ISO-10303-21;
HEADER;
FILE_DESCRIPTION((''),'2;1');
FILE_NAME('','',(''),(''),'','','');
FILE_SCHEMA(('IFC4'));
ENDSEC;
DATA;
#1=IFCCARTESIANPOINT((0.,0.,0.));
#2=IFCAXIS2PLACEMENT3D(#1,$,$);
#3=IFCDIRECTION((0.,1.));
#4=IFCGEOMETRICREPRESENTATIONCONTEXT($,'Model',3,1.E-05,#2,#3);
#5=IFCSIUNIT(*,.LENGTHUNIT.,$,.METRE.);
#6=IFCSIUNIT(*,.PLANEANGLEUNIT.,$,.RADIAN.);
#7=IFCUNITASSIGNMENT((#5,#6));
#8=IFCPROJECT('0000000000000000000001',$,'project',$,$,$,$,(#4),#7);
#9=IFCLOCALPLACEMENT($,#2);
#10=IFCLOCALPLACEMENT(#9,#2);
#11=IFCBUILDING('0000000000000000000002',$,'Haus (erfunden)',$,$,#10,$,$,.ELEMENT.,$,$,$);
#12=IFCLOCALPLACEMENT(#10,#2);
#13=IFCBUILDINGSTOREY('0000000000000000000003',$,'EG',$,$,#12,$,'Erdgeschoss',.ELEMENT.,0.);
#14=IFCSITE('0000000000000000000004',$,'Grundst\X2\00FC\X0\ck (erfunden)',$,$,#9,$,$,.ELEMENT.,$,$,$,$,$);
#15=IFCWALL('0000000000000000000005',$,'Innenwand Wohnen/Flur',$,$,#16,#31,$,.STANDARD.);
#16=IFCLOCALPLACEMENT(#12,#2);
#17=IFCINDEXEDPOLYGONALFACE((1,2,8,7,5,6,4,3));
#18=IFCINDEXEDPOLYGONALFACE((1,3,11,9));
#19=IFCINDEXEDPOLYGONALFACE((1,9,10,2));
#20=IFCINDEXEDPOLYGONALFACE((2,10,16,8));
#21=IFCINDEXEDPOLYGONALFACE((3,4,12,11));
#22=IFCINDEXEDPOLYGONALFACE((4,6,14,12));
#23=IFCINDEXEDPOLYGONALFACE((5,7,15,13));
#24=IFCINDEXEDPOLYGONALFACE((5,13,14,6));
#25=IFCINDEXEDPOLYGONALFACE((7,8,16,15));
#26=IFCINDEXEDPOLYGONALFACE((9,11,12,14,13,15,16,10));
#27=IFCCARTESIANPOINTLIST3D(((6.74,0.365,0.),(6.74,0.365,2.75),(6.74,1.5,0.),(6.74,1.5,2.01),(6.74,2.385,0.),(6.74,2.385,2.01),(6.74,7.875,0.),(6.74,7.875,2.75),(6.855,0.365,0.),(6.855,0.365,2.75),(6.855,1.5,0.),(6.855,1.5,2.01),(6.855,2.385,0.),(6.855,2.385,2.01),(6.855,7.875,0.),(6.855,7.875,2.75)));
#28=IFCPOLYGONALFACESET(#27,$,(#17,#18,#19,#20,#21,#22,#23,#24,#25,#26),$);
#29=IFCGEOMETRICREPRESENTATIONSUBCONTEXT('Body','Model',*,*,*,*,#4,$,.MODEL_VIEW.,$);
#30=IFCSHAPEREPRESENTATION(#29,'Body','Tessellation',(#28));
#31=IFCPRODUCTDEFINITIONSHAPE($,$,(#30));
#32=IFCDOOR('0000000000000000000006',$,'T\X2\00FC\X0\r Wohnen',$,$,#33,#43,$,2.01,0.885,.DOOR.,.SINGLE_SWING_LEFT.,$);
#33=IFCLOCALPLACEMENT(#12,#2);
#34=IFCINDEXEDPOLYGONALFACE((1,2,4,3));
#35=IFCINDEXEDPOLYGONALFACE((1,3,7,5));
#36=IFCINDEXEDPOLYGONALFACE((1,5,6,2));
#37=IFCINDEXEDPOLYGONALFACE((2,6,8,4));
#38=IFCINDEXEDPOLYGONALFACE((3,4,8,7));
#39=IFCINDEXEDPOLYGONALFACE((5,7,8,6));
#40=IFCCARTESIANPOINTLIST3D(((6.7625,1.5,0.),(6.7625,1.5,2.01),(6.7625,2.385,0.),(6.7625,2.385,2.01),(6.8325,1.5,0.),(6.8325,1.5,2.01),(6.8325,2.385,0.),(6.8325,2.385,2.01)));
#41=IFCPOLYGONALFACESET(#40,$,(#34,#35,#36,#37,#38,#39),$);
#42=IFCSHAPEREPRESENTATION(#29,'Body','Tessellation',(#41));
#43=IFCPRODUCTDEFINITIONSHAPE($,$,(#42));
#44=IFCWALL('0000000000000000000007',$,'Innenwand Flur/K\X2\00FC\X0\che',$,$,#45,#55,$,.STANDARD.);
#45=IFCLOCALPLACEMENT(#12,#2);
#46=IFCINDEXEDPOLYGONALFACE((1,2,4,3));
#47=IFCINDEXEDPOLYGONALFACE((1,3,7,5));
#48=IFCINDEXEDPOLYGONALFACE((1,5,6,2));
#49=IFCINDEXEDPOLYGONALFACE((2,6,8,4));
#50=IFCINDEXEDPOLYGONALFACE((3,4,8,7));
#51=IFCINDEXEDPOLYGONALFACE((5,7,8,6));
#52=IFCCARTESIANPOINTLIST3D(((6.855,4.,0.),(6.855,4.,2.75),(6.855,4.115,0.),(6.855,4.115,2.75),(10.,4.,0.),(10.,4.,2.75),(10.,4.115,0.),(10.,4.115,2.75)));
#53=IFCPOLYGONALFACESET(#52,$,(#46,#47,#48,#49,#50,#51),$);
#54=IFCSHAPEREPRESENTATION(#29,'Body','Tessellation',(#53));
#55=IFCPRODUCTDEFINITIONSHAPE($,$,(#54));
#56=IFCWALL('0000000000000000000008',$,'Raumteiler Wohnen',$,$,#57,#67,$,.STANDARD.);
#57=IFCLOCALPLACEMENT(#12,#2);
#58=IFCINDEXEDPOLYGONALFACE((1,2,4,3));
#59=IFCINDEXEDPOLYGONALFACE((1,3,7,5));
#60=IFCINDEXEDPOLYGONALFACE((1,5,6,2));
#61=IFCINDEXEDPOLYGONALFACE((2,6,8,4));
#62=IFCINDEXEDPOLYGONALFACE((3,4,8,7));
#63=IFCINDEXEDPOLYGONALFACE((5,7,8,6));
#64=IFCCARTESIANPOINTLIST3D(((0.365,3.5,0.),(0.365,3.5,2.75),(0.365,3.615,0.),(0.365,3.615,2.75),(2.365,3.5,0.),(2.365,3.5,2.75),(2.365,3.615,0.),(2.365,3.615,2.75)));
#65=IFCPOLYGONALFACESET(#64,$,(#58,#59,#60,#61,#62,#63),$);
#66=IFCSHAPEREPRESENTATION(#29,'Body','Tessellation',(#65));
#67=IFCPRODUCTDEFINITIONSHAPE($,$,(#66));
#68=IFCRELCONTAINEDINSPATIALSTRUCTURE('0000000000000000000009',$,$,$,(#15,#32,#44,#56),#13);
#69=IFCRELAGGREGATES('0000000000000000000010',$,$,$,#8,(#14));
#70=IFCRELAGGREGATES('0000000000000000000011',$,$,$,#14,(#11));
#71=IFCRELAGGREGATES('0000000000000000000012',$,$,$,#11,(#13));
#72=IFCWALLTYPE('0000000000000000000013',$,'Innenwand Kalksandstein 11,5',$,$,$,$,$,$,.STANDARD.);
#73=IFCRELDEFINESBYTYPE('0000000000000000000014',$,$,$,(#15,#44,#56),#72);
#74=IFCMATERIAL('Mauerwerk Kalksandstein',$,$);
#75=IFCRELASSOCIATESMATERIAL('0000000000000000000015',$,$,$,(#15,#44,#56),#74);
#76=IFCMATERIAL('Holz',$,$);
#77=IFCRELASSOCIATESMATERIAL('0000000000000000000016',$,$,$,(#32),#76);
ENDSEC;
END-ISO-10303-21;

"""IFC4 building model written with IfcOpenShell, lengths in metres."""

from ifc_helpers import new_model, si_unit, direction, frame, frame_2d, origin, place, context, subcontext, project, spatial, rectangle, extrude, material, type_object, element, fill, save


model = new_model("IFC4")

# Units and contexts
model_context = context("Model", 3, precision=1e-05, world=origin(), true_north=direction((0.0, 1.0)))
body_context = subcontext(model_context, "Body", "Model", "MODEL_VIEW")
ifc_project = project(units=[si_unit("LENGTHUNIT", "METRE"), si_unit("PLANEANGLEUNIT", "RADIAN")], contexts=[model_context])

# Site, building, storey
site_placement = place(None, origin())
site = spatial("IfcSite", under=ifc_project, at=site_placement, Name="Grundstück (erfunden)", CompositionType="ELEMENT")
building_placement = place(site_placement, origin())
building = spatial("IfcBuilding", under=site, at=building_placement, Name="Haus (erfunden)", CompositionType="ELEMENT")
storey_placement = place(building_placement, origin())
storey = spatial("IfcBuildingStorey", under=building, at=storey_placement, Name="EG", LongName="Erdgeschoss", CompositionType="ELEMENT", Elevation=0.0)

# Shared definitions
ifc_material_1 = material(Name="Holz")

# Wall, opening, door
ifc_material_2 = material(Name="Mauerwerk Kalksandstein")
wall_type_1 = type_object("IfcWallType", Name="Innenwand Kalksandstein 11,5", PredefinedType="STANDARD")
wall_1_placement = place(storey_placement, frame((6.74, 0.365, 0.0)))
wall_1 = element("IfcWall", 1, at=wall_1_placement, inside=storey, type_object=wall_type_1, material=ifc_material_2, Name="Innenwand Wohnen/Flur", PredefinedType="STANDARD", context=body_context, shape_type="SweptSolid", body=[
    extrude(rectangle(XDim=0.115, YDim=7.51, at=frame_2d((0.0575, 3.755))), origin(), (0.0, 0.0, 1.0), 2.75),
])
opening_1_placement = place(wall_1_placement, frame((-0.05, 1.135, 0.0)))
opening_1 = element("IfcOpeningElement", 2, at=opening_1_placement, cuts=wall_1, PredefinedType="OPENING", context=body_context, shape_type="SweptSolid", body=[
    extrude(rectangle(XDim=0.215, YDim=0.885, at=frame_2d((0.1075, 0.4425))), origin(), (0.0, 0.0, 1.0), 2.01),
])
door_1_placement = place(opening_1_placement, frame((0.0725, 0.0, 0.0)))
door_1 = element("IfcDoor", 3, at=door_1_placement, inside=storey, material=ifc_material_1, Name="Tür Wohnen", OperationType="SINGLE_SWING_LEFT", OverallHeight=2.01, OverallWidth=0.885, PredefinedType="DOOR", context=body_context, shape_type="SweptSolid", body=[
    extrude(rectangle(XDim=0.07, YDim=0.885, at=frame_2d((0.035, 0.4425))), origin(), (0.0, 0.0, 1.0), 2.01),
])
fill(opening_1, door_1)

# Walls
wall_2_placement = place(storey_placement, frame((6.855, 4.0, 0.0)))
element("IfcWall", 4, at=wall_2_placement, inside=storey, type_object=wall_type_1, material=ifc_material_2, Name="Innenwand Flur/Küche", PredefinedType="STANDARD", context=body_context, shape_type="SweptSolid", body=[
    extrude(rectangle(XDim=3.145, YDim=0.115, at=frame_2d((1.5725, 0.0575))), origin(), (0.0, 0.0, 1.0), 2.75),
])
wall_3_placement = place(storey_placement, frame((0.365, 3.5, 0.0)))
element("IfcWall", 5, at=wall_3_placement, inside=storey, type_object=wall_type_1, material=ifc_material_2, Name="Raumteiler Wohnen", PredefinedType="STANDARD", context=body_context, shape_type="SweptSolid", body=[
    extrude(rectangle(XDim=2.0, YDim=0.115, at=frame_2d((1.0, 0.0575))), origin(), (0.0, 0.0, 1.0), 2.75),
])

save(model, "model.ifc")
